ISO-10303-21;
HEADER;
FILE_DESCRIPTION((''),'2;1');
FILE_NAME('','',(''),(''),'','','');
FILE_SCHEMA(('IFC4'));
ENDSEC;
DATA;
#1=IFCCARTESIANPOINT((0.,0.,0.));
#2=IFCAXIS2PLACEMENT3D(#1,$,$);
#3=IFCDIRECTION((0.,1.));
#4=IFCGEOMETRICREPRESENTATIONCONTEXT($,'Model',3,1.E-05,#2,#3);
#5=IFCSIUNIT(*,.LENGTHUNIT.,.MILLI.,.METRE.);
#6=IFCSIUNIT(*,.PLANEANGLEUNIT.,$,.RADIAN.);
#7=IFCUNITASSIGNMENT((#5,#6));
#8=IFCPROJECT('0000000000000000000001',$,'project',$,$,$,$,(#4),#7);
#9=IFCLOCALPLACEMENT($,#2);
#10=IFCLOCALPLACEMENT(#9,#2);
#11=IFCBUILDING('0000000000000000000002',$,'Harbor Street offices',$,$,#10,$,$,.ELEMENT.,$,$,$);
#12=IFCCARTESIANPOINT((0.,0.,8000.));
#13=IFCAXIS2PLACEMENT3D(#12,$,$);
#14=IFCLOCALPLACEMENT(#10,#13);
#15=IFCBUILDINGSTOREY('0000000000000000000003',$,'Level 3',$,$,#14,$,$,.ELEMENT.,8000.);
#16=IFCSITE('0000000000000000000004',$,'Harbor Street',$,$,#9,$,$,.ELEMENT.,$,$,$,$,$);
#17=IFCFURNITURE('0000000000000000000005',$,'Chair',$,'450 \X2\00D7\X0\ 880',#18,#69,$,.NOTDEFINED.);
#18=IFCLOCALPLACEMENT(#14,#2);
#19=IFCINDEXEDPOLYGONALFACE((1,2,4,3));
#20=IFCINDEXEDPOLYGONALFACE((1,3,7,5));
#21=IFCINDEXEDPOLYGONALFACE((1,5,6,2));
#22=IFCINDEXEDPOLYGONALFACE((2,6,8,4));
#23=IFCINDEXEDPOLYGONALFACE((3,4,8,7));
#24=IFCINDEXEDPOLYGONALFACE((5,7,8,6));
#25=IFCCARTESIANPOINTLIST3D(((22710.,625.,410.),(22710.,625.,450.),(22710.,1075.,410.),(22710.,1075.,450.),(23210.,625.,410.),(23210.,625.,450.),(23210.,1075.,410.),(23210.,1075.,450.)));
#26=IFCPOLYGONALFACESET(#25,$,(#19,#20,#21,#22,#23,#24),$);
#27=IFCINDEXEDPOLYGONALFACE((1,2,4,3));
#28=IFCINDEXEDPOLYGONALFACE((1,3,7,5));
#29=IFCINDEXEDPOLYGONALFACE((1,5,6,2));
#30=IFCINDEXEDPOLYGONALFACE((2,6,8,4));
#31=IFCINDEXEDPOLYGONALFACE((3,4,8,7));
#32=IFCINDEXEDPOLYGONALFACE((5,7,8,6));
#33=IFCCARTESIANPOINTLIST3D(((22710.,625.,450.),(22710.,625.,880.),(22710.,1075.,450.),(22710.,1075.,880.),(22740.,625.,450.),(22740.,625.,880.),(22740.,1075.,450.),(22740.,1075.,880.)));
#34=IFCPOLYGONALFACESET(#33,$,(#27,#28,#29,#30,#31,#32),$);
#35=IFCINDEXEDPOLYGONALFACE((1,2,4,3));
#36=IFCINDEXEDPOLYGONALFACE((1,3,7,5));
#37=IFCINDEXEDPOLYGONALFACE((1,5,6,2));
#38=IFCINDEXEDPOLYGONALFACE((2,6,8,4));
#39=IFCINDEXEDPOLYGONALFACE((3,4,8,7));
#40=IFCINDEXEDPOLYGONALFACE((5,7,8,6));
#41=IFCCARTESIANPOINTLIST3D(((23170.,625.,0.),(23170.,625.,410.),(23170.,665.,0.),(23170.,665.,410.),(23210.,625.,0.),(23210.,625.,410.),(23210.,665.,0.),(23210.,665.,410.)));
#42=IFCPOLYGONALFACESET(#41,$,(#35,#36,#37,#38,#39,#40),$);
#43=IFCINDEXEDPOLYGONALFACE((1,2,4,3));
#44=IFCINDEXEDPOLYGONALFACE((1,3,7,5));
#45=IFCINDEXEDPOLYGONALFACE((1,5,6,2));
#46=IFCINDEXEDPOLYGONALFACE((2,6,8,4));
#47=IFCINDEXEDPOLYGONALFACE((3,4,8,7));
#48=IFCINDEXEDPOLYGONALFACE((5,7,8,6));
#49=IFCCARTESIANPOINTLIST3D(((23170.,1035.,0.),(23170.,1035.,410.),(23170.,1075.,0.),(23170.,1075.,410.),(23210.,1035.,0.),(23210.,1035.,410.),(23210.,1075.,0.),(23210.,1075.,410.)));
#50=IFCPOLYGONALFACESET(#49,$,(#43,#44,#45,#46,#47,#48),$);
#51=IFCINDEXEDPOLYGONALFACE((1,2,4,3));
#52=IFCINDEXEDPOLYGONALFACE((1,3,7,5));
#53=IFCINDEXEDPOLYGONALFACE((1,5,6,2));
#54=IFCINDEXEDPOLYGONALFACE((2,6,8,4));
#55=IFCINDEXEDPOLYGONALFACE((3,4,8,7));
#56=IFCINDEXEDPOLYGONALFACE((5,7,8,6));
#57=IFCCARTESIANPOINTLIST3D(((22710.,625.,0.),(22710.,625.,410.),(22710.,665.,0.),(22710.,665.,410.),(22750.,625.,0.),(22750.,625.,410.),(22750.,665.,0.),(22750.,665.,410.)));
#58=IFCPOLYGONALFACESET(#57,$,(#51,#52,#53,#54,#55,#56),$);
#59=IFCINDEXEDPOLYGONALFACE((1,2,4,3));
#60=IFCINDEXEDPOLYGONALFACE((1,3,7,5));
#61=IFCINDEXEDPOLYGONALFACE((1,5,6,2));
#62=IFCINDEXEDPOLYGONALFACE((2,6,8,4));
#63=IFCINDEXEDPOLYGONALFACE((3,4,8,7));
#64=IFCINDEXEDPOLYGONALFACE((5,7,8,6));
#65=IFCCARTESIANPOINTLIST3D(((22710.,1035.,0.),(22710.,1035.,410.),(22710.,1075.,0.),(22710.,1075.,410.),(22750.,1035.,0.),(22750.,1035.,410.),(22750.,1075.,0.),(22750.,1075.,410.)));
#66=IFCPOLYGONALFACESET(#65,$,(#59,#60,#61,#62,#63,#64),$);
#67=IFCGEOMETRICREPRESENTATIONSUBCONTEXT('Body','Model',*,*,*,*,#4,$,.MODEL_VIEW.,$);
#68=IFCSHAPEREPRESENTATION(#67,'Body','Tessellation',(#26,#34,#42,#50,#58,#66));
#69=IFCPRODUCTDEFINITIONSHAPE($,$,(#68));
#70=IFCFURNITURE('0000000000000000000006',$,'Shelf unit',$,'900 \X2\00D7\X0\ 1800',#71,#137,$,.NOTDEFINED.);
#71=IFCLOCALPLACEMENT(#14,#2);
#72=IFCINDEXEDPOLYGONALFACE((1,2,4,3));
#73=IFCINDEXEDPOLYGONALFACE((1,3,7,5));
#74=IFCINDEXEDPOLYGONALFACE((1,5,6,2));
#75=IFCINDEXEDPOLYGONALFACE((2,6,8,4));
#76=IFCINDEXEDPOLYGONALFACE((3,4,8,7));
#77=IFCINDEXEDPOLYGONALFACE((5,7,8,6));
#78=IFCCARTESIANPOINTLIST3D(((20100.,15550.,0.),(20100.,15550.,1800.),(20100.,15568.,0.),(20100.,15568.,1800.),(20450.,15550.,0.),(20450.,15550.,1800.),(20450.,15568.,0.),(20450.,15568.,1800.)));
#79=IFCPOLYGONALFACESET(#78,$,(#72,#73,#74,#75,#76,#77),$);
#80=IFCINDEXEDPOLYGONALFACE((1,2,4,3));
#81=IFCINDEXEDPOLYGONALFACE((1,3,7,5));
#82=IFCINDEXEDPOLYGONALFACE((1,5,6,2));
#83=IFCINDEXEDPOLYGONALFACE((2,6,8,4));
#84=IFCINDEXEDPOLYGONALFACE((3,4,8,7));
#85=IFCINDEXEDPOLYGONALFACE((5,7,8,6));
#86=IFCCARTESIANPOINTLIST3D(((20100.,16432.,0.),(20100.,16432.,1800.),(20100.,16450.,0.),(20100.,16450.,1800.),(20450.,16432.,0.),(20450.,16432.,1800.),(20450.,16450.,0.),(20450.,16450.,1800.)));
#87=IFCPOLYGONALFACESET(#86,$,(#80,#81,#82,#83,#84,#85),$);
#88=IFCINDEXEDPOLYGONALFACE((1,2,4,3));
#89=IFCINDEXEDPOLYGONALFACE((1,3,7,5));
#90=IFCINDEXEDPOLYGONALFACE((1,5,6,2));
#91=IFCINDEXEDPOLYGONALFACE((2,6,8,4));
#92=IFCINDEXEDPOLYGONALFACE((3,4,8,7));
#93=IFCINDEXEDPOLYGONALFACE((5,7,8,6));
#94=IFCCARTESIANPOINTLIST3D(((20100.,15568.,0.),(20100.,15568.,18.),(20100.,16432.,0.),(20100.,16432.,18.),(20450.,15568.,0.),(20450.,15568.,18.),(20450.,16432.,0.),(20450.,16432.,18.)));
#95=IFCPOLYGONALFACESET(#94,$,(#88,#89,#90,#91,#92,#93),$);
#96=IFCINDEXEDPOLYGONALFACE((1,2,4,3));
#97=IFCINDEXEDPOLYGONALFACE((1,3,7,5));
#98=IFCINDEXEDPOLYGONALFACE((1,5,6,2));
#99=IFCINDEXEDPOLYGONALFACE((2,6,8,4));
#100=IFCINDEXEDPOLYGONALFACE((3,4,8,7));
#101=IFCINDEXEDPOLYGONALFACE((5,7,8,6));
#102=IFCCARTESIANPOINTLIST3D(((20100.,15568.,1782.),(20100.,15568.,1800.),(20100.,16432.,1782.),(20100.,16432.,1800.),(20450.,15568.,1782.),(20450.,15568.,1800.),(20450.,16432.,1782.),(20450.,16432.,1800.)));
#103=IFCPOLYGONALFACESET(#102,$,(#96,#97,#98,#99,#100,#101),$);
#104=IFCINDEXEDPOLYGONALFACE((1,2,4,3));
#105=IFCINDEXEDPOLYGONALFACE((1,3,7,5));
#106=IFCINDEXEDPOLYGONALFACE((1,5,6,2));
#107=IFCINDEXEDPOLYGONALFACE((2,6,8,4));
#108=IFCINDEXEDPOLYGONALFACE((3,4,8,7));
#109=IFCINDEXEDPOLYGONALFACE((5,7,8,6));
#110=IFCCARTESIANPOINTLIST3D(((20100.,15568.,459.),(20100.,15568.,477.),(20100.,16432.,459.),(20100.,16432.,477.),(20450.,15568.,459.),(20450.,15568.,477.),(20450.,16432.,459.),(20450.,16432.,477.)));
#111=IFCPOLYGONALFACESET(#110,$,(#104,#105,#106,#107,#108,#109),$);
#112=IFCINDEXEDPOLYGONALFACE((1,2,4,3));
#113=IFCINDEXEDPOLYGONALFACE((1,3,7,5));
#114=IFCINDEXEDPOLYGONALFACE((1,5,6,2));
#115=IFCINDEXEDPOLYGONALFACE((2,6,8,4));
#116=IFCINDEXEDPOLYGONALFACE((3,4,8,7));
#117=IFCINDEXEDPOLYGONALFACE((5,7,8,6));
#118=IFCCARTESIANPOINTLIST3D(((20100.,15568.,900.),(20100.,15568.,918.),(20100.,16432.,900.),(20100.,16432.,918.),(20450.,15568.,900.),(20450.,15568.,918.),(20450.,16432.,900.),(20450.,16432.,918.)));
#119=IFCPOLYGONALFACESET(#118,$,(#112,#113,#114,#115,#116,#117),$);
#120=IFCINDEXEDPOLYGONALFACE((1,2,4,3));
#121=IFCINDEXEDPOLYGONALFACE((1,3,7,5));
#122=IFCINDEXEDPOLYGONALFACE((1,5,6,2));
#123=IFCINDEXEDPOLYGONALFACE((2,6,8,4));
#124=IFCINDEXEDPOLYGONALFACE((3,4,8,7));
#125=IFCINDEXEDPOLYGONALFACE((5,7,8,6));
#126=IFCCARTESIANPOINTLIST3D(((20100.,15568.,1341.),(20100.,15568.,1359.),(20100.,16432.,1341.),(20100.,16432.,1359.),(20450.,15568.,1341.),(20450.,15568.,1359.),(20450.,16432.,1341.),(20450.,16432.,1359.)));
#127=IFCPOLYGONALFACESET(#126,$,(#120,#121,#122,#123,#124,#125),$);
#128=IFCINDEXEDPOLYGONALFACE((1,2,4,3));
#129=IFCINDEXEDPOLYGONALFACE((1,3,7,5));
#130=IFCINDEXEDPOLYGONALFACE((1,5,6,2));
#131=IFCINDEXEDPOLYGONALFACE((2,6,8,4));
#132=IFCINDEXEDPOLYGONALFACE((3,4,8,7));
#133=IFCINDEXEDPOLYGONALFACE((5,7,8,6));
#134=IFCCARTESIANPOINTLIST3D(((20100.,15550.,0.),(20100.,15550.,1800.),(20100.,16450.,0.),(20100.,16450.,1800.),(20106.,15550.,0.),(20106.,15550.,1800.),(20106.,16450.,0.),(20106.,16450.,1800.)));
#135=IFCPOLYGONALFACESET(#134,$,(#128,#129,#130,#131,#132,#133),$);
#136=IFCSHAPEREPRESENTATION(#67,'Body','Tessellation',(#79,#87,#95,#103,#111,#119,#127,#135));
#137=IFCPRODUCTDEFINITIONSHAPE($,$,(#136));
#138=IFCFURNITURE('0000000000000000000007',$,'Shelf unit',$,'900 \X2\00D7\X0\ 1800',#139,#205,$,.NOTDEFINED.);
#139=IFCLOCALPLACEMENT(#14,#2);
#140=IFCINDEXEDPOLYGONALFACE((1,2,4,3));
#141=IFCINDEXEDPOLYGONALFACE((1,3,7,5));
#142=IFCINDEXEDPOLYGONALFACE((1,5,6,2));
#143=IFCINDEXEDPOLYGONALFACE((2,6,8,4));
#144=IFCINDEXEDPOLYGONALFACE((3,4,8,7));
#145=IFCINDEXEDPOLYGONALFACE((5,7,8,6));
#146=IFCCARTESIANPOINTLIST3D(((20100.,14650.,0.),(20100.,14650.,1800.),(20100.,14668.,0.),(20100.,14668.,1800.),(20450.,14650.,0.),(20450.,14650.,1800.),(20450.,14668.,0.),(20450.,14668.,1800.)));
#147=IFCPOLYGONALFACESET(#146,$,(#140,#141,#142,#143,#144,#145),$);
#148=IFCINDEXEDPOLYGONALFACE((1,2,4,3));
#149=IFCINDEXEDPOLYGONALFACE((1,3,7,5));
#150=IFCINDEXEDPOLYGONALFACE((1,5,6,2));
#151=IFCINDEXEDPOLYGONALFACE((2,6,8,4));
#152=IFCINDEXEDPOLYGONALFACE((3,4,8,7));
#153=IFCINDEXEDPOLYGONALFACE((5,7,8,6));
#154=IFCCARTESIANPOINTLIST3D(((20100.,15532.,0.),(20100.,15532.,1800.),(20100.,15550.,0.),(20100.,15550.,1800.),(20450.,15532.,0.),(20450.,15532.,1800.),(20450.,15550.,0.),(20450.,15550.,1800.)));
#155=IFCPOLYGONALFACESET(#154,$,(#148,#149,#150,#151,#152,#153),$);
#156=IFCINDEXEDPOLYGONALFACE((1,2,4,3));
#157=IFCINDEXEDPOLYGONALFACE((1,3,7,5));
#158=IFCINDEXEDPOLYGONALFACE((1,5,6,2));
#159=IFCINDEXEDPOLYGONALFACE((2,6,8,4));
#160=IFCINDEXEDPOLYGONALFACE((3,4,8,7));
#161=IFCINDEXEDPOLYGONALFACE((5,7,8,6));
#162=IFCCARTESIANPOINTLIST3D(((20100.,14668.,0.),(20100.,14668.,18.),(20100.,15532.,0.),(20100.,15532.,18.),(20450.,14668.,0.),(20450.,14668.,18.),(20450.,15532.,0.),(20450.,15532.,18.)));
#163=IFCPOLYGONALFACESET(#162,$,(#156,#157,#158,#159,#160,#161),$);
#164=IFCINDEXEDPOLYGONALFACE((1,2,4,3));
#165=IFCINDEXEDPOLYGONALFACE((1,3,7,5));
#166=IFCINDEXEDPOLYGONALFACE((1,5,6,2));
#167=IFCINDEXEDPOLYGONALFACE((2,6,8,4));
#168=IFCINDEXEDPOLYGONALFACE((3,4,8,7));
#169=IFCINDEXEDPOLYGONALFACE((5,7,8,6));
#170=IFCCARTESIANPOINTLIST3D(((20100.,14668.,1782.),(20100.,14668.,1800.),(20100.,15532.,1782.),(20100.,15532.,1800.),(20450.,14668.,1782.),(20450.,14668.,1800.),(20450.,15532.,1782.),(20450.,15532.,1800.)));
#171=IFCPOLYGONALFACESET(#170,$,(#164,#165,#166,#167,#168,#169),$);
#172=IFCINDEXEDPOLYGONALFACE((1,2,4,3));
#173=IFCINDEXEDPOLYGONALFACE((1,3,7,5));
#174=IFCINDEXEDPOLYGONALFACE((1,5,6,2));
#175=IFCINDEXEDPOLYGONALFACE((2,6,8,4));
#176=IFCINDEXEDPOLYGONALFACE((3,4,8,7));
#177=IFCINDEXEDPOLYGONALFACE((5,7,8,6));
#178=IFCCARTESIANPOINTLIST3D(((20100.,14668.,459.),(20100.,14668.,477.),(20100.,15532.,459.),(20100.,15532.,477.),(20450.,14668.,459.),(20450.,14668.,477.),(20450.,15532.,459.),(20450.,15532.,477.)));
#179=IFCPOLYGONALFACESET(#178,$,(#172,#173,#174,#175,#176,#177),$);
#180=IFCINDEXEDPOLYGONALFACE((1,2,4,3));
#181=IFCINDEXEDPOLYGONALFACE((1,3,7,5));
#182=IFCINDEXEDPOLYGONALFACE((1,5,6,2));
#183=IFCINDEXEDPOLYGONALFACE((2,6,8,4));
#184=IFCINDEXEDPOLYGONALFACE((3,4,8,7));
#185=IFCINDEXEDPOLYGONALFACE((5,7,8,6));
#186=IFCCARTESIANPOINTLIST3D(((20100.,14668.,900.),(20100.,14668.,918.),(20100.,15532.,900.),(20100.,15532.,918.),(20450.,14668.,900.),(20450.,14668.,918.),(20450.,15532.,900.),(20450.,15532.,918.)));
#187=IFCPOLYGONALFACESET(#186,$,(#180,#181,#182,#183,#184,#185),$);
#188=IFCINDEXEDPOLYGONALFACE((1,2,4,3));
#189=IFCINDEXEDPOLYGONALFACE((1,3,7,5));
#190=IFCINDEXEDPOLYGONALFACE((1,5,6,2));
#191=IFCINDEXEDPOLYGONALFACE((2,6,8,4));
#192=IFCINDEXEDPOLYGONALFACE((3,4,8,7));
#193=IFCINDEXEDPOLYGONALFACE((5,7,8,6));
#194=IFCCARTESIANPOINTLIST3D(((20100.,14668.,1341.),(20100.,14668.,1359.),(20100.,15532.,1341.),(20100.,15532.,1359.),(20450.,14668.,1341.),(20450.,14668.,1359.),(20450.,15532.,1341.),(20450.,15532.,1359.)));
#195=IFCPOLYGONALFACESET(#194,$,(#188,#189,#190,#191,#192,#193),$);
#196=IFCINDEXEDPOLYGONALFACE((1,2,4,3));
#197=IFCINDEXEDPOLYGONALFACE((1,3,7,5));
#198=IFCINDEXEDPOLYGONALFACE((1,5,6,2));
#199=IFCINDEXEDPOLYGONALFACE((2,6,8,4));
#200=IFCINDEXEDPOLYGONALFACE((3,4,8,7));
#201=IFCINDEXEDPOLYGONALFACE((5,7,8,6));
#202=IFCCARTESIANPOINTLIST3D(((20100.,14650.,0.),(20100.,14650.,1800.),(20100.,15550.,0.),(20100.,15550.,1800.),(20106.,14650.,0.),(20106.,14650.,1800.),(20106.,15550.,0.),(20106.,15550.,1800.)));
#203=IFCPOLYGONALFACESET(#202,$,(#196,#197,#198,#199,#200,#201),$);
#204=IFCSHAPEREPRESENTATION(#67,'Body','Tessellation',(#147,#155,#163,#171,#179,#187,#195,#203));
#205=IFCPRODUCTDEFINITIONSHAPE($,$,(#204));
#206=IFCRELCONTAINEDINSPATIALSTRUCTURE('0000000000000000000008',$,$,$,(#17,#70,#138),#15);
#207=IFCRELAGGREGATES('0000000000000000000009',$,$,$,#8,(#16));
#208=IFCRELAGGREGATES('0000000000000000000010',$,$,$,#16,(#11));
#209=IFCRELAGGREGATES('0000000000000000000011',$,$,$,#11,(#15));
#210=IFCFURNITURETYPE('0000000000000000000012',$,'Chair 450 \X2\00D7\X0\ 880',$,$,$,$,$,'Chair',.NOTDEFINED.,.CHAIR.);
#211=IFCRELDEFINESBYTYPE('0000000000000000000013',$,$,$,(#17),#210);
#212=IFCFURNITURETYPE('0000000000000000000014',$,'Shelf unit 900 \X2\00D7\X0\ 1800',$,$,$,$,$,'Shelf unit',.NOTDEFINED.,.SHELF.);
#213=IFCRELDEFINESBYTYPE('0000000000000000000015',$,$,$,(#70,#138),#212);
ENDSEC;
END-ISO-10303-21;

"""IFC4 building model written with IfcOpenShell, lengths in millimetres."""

from ifc_helpers import new_model, si_unit, direction, frame, origin, place, context, subcontext, project, spatial, polyline, outline, extrude, source, transform, mapped, type_object, type_shapes, element, save


model = new_model("IFC4")

# Units and contexts
model_context = context("Model", 3, precision=1e-05, world=origin(), true_north=direction((0.0, 1.0)))
body_context = subcontext(model_context, "Body", "Model", "MODEL_VIEW")
ifc_project = project(units=[si_unit("LENGTHUNIT", "METRE", prefix="MILLI"), si_unit("PLANEANGLEUNIT", "RADIAN")], contexts=[model_context])

# Site, building, storey
site_placement = place(None, origin())
site = spatial("IfcSite", under=ifc_project, at=site_placement, Name="Harbor Street", CompositionType="ELEMENT")
building_placement = place(site_placement, origin())
building = spatial("IfcBuilding", under=site, at=building_placement, Name="Harbor Street offices", CompositionType="ELEMENT")
storey_placement = place(building_placement, frame((0.0, 0.0, 8000.0)))
storey = spatial("IfcBuildingStorey", under=building, at=storey_placement, Name="Level 3", CompositionType="ELEMENT", Elevation=8000.0)

# Furniture
furniture_type_1 = type_object("IfcFurnitureType", Name="Chair 450 × 880", ElementType="Chair", AssemblyPlace="NOTDEFINED", PredefinedType="CHAIR")
shared_shape_1 = source(origin(), body_context, "Body", "SweptSolid", [
    extrude(outline(polyline([(-225.0, 0.0), (225.0, 0.0), (225.0, 500.0), (-225.0, 500.0), (-225.0, 0.0)])), frame((0.0, 0.0, 410.0)), (0.0, 0.0, 1.0), 40.0),
    extrude(outline(polyline([(-225.0, 470.0), (225.0, 470.0), (225.0, 500.0), (-225.0, 500.0), (-225.0, 470.0)])), frame((0.0, 0.0, 450.0)), (0.0, 0.0, 1.0), 430.0),
    extrude(outline(polyline([(-225.0, 0.0), (-185.0, 0.0), (-185.0, 40.0), (-225.0, 40.0), (-225.0, 0.0)])), origin(), (0.0, 0.0, 1.0), 410.0),
    extrude(outline(polyline([(185.0, 0.0), (225.0, 0.0), (225.0, 40.0), (185.0, 40.0), (185.0, 0.0)])), origin(), (0.0, 0.0, 1.0), 410.0),
    extrude(outline(polyline([(-225.0, 460.0), (-185.0, 460.0), (-185.0, 500.0), (-225.0, 500.0), (-225.0, 460.0)])), origin(), (0.0, 0.0, 1.0), 410.0),
    extrude(outline(polyline([(185.0, 460.0), (225.0, 460.0), (225.0, 500.0), (185.0, 500.0), (185.0, 460.0)])), origin(), (0.0, 0.0, 1.0), 410.0),
])
type_shapes(furniture_type_1, [shared_shape_1])
for number, where, z_axis, x_axis, name in (
    (1, (23210.0, 850.0, 0.0), (0.0, 0.0, 1.0), (0.0, 1.0, 0.0), "Chair"),
):
    element("IfcFurniture", number, at=place(storey_placement, frame(where, z_axis=z_axis, x_axis=x_axis)), inside=storey, type_object=furniture_type_1, Name=name, ObjectType="450 × 880", PredefinedType="NOTDEFINED", context=body_context, shape_type="MappedRepresentation", body=[
        mapped(shared_shape_1, transform((0.0, 0.0, 0.0))),
    ])
furniture_type_2 = type_object("IfcFurnitureType", Name="Shelf unit 900 × 1800", ElementType="Shelf unit", AssemblyPlace="NOTDEFINED", PredefinedType="SHELF")
shared_shape_2 = source(origin(), body_context, "Body", "SweptSolid", [
    extrude(outline(polyline([(-450.0, 0.0), (-432.0, 0.0), (-432.0, 350.0), (-450.0, 350.0), (-450.0, 0.0)])), origin(), (0.0, 0.0, 1.0), 1800.0),
    extrude(outline(polyline([(432.0, 0.0), (450.0, 0.0), (450.0, 350.0), (432.0, 350.0), (432.0, 0.0)])), origin(), (0.0, 0.0, 1.0), 1800.0),
    extrude(outline(polyline([(-432.0, 0.0), (432.0, 0.0), (432.0, 350.0), (-432.0, 350.0), (-432.0, 0.0)])), origin(), (0.0, 0.0, 1.0), 18.0),
    extrude(outline(polyline([(-432.0, 0.0), (432.0, 0.0), (432.0, 350.0), (-432.0, 350.0), (-432.0, 0.0)])), frame((0.0, 0.0, 1782.0)), (0.0, 0.0, 1.0), 18.0),
    extrude(outline(polyline([(-432.0, 0.0), (432.0, 0.0), (432.0, 350.0), (-432.0, 350.0), (-432.0, 0.0)])), frame((0.0, 0.0, 459.0)), (0.0, 0.0, 1.0), 18.0),
    extrude(outline(polyline([(-432.0, 0.0), (432.0, 0.0), (432.0, 350.0), (-432.0, 350.0), (-432.0, 0.0)])), frame((0.0, 0.0, 900.0)), (0.0, 0.0, 1.0), 18.0),
    extrude(outline(polyline([(-432.0, 0.0), (432.0, 0.0), (432.0, 350.0), (-432.0, 350.0), (-432.0, 0.0)])), frame((0.0, 0.0, 1341.0)), (0.0, 0.0, 1.0), 18.0),
    extrude(outline(polyline([(-450.0, 344.0), (450.0, 344.0), (450.0, 350.0), (-450.0, 350.0), (-450.0, 344.0)])), origin(), (0.0, 0.0, 1.0), 1800.0),
])
type_shapes(furniture_type_2, [shared_shape_2])
for number, where, z_axis, x_axis, name in (
    (2, (20450.0, 16000.0, 0.0), (0.0, 0.0, 1.0), (0.0, 1.0, 0.0), "Shelf unit"),
    (3, (20450.0, 15100.0, 0.0), (0.0, 0.0, 1.0), (0.0, 1.0, 0.0), "Shelf unit"),
):
    element("IfcFurniture", number, at=place(storey_placement, frame(where, z_axis=z_axis, x_axis=x_axis)), inside=storey, type_object=furniture_type_2, Name=name, ObjectType="900 × 1800", PredefinedType="NOTDEFINED", context=body_context, shape_type="MappedRepresentation", body=[
        mapped(shared_shape_2, transform((0.0, 0.0, 0.0))),
    ])

save(model, "model.ifc")
